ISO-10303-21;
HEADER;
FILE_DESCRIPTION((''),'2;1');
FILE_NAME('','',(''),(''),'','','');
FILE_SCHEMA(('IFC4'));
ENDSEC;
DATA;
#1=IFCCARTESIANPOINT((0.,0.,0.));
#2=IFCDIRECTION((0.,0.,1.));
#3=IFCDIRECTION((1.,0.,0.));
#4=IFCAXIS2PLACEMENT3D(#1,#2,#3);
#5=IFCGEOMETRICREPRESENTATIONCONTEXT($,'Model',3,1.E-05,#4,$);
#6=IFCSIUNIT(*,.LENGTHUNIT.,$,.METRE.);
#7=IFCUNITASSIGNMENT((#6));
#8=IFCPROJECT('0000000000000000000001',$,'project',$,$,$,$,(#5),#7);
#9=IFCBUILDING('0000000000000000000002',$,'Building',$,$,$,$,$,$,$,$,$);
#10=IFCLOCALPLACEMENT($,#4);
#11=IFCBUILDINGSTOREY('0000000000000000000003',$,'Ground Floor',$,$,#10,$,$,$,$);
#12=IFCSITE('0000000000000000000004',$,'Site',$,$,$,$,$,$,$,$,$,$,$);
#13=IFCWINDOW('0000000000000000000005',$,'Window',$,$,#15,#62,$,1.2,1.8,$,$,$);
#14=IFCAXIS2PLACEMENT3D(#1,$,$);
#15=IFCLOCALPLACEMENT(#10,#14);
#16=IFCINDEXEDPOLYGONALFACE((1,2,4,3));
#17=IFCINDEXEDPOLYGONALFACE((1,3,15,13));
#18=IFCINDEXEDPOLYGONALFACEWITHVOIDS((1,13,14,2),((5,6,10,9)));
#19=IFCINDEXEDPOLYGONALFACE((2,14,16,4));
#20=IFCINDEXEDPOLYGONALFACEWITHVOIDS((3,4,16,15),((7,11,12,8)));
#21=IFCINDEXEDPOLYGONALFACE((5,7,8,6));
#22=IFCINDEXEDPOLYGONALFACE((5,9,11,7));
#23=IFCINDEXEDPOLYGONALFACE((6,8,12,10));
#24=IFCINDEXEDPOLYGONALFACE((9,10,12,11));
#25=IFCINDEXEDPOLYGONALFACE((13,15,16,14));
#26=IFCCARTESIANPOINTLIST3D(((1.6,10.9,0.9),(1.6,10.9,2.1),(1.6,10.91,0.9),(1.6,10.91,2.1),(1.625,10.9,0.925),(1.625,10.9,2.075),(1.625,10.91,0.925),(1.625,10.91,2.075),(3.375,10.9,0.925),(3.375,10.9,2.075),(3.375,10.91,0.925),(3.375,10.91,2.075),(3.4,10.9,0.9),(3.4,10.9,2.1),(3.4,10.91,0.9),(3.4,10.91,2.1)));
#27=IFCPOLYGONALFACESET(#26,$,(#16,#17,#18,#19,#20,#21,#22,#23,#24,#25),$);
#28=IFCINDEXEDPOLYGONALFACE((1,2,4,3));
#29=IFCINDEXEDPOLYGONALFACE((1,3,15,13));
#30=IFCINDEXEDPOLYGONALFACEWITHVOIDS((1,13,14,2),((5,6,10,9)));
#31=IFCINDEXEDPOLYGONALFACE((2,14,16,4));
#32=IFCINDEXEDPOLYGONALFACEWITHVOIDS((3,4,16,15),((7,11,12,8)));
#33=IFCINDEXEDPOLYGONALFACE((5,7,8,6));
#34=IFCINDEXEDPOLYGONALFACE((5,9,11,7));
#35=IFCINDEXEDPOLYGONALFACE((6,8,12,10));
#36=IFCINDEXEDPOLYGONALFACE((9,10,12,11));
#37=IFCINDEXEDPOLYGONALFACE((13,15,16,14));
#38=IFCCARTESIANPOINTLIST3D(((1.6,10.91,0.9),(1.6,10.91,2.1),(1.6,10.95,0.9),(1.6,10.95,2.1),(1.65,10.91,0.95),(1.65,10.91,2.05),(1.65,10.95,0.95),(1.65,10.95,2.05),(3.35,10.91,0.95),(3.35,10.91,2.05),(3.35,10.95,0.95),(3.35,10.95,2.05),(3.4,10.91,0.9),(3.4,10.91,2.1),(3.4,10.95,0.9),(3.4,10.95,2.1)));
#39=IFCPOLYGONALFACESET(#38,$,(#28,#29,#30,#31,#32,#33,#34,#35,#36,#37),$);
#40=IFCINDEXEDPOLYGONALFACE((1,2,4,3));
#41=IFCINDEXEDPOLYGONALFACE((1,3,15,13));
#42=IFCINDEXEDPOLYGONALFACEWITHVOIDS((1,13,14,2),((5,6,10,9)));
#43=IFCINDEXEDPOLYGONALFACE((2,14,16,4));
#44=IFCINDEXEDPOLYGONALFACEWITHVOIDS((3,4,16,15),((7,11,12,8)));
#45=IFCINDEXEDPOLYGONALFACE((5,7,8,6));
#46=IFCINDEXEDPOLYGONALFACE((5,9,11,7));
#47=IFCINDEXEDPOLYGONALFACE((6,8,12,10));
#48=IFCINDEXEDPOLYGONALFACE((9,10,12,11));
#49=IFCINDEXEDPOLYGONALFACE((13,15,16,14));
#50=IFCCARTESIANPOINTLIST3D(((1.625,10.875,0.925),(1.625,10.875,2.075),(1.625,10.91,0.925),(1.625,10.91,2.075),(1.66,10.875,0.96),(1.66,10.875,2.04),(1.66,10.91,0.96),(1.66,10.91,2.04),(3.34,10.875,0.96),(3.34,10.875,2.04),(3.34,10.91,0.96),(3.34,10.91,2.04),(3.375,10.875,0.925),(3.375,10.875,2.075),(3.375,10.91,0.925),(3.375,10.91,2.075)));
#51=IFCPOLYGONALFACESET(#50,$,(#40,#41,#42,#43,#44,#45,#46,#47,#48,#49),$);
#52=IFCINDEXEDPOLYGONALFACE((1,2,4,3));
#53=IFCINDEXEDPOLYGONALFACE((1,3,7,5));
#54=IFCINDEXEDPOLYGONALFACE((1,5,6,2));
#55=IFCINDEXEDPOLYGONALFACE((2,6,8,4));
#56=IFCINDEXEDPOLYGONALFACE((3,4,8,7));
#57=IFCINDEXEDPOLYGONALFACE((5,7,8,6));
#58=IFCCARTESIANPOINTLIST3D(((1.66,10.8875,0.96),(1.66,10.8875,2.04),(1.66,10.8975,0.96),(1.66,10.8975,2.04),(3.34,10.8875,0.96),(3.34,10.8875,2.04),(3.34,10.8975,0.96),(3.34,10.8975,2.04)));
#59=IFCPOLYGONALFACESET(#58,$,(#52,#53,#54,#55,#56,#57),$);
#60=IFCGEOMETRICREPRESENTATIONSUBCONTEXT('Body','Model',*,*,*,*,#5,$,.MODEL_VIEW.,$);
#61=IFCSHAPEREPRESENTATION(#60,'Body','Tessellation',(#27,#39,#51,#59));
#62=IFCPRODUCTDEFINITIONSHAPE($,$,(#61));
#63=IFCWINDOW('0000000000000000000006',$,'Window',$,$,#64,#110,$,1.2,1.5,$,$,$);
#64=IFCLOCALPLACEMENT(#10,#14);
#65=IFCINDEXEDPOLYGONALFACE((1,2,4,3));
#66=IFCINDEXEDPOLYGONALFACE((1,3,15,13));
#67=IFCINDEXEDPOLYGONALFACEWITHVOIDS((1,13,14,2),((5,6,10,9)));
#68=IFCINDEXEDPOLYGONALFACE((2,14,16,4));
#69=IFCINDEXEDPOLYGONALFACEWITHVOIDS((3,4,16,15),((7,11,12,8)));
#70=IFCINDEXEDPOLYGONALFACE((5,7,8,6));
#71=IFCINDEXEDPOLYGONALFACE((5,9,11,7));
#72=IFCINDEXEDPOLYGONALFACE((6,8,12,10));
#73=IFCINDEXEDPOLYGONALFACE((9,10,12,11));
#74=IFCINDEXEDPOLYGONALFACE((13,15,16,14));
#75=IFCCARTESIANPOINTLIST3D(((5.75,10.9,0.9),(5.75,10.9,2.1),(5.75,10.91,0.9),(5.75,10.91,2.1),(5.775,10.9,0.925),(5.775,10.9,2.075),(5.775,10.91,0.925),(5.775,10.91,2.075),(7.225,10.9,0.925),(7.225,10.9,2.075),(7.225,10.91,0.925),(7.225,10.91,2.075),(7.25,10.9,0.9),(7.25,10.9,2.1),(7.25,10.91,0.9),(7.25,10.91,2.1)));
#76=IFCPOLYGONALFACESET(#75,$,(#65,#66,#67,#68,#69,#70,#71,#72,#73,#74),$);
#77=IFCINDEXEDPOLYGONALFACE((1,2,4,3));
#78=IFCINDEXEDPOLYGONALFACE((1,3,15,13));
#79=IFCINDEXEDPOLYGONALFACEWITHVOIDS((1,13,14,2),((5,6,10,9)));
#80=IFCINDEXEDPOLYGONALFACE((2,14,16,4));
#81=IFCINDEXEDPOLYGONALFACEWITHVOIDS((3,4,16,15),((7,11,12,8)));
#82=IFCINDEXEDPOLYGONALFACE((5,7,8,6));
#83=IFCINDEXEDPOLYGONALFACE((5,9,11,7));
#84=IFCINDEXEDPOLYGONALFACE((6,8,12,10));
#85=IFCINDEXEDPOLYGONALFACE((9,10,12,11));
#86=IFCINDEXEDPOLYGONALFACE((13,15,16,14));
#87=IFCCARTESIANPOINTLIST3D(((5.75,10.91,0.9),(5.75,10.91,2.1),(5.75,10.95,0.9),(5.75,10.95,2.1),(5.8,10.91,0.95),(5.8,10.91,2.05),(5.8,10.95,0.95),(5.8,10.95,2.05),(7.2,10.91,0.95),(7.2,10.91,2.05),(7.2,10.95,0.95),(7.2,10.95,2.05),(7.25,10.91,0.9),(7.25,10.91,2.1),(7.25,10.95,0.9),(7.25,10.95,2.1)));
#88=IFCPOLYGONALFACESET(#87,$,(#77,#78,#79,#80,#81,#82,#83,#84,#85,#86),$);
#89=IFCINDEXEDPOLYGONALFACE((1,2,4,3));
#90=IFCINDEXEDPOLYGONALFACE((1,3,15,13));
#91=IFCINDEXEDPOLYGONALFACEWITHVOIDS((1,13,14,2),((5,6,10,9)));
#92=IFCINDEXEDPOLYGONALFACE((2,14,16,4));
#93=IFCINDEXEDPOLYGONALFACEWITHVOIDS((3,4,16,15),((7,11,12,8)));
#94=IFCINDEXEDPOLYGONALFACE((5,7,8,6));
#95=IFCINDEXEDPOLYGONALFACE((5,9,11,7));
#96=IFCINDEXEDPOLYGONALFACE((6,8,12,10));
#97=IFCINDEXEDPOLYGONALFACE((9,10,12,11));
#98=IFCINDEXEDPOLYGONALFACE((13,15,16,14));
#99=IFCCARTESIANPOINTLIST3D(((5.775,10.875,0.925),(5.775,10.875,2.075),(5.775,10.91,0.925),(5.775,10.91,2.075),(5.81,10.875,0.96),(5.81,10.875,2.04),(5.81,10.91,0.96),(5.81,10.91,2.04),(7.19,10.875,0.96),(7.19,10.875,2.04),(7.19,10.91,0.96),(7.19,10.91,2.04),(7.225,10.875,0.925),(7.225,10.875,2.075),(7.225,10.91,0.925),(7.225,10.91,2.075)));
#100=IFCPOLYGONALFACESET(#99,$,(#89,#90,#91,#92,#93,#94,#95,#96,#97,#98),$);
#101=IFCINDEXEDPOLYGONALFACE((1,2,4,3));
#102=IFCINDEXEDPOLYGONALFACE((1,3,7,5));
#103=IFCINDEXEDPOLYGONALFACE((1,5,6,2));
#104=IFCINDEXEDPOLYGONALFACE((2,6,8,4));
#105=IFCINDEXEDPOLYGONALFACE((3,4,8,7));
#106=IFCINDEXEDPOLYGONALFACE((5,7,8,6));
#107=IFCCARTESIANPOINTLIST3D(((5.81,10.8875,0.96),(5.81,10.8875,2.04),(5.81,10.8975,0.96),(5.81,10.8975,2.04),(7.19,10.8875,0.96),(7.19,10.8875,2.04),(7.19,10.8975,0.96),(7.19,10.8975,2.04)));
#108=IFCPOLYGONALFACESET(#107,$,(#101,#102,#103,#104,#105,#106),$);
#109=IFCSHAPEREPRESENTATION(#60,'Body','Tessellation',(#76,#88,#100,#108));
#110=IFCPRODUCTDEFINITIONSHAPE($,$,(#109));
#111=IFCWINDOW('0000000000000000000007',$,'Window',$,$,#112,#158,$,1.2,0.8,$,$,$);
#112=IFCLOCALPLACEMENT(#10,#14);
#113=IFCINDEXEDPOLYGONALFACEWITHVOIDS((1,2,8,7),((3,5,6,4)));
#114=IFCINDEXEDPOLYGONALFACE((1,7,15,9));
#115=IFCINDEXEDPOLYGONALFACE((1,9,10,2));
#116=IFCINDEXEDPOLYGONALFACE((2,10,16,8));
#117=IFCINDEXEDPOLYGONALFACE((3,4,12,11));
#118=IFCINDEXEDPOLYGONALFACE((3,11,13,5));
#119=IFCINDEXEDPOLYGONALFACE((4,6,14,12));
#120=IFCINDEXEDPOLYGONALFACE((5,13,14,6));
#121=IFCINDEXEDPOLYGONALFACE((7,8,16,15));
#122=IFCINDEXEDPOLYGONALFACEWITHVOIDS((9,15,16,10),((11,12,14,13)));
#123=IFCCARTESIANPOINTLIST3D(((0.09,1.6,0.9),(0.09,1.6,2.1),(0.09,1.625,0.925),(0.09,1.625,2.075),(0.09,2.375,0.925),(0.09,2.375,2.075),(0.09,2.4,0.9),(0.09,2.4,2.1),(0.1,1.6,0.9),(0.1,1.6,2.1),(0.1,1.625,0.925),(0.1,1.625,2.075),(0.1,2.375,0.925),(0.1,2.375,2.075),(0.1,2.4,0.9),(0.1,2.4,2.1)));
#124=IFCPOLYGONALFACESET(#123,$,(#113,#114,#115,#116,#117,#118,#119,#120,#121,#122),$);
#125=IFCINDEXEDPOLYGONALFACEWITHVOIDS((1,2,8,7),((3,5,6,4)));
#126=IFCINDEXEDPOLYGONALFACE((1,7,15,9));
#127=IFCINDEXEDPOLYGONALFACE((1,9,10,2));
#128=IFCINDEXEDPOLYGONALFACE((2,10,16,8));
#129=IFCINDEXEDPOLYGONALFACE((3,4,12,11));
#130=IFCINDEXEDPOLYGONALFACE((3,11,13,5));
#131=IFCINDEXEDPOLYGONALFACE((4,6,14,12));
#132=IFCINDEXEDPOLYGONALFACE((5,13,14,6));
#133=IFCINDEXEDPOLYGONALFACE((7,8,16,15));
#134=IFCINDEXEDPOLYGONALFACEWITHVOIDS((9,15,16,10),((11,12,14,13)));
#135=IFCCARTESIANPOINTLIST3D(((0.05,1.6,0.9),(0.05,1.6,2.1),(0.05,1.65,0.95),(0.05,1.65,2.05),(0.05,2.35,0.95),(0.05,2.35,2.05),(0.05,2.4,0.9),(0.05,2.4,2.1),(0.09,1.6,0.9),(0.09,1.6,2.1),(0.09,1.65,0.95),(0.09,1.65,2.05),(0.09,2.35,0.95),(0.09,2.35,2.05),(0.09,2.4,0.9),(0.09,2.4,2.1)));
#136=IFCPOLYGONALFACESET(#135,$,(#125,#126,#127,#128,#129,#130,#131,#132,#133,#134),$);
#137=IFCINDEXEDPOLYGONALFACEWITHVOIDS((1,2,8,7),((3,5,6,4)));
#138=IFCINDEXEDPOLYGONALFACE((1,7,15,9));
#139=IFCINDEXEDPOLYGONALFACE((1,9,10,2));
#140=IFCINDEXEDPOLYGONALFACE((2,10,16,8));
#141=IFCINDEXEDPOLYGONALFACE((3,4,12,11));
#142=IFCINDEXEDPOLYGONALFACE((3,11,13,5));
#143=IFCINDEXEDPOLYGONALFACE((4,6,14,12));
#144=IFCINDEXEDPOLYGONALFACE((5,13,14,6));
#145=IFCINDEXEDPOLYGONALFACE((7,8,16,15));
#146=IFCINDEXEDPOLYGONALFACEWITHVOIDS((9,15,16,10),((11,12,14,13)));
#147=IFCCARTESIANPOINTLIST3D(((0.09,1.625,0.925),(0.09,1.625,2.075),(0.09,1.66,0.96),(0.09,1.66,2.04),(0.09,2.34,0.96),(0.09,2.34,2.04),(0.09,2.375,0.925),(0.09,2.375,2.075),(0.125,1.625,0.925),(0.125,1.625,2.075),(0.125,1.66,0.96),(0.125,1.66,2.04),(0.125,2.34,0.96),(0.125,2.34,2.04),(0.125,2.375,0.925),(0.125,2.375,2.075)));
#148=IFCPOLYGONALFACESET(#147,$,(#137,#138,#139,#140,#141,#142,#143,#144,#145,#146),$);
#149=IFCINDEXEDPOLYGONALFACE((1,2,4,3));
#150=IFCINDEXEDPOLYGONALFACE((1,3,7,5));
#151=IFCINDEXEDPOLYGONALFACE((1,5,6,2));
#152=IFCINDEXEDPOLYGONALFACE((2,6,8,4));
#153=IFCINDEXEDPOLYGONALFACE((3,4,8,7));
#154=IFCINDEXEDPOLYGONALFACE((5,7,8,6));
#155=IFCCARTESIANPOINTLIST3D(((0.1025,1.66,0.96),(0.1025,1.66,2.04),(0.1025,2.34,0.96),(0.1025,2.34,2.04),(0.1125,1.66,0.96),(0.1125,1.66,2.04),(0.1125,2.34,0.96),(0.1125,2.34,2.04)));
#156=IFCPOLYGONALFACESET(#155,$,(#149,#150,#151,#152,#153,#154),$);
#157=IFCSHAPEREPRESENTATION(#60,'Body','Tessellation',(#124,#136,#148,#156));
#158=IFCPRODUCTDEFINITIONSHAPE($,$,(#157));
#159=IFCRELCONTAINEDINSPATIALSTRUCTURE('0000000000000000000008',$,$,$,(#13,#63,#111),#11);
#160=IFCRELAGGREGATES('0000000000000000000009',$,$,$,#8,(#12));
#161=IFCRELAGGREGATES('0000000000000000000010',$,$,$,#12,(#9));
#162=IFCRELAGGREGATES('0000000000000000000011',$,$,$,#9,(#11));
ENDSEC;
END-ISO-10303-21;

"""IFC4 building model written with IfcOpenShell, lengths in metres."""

from ifc_helpers import new_model, si_unit, frame, origin_with_axes, place, context, subcontext, project, spatial, line, indexed_curve, outline, extrude, element, save


model = new_model("IFC4")

# Units and contexts
model_context = context("Model", 3, precision=1e-05, world=origin_with_axes())
body_context = subcontext(model_context, "Body", "Model", "MODEL_VIEW")
ifc_project = project(units=[si_unit("LENGTHUNIT", "METRE")], contexts=[model_context])

# Site, building, storey
site = spatial("IfcSite", under=ifc_project, Name="Site")
building = spatial("IfcBuilding", under=site, Name="Building")
storey_placement = place(None, origin_with_axes())
storey = spatial("IfcBuildingStorey", under=building, at=storey_placement, Name="Ground Floor")

# Windows
for number, where, z_axis, x_axis, name in (
    (1, (3.4, 11.0, 0.9), (0.0, 0.0, 1.0), (-1.0, 0.0, 0.0), "Window"),
):
    element("IfcWindow", number, at=place(storey_placement, frame(where, z_axis=z_axis, x_axis=x_axis)), inside=storey, Name=name, OverallHeight=1.2, OverallWidth=1.8, context=body_context, shape_type="SweptSolid", body=[
        extrude(outline(indexed_curve([(0.0, 0.0), (1.8, 0.0), (1.8, 1.2), (0.0, 1.2)], segments=[line(1, 2, 3, 4, 1)]), holes=[indexed_curve([(0.025, 0.025), (1.775, 0.025), (1.775, 1.175), (0.025, 1.175)], segments=[line(1, 2, 3, 4, 1)])]), frame((0.0, 0.09, 0.0), z_axis=(0.0, -1.0, 0.0), x_axis=(1.0, 0.0, 0.0)), (0.0, 0.0, -1.0), 0.01),
        extrude(outline(indexed_curve([(0.0, 0.0), (1.8, 0.0), (1.8, 1.2), (0.0, 1.2)], segments=[line(1, 2, 3, 4, 1)]), holes=[indexed_curve([(0.05, 0.05), (1.75, 0.05), (1.75, 1.15), (0.05, 1.15)], segments=[line(1, 2, 3, 4, 1)])]), frame((0.0, 0.05, 0.0), z_axis=(0.0, -1.0, 0.0), x_axis=(1.0, 0.0, 0.0)), (0.0, 0.0, -1.0), 0.04),
        extrude(outline(indexed_curve([(0.0, 0.0), (1.75, 0.0), (1.75, 1.15), (0.0, 1.15)], segments=[line(1, 2, 3, 4, 1)]), holes=[indexed_curve([(0.035, 0.035), (1.715, 0.035), (1.715, 1.115), (0.035, 1.115)], segments=[line(1, 2, 3, 4, 1)])]), frame((0.025, 0.09, 0.025), z_axis=(0.0, -1.0, 0.0), x_axis=(1.0, 0.0, 0.0)), (0.0, 0.0, -1.0), 0.035),
        extrude(outline(indexed_curve([(0.035, 0.035), (1.715, 0.035), (1.715, 1.115), (0.035, 1.115)], segments=[line(1, 2, 3, 4, 1)])), frame((0.025, 0.1025, 0.025), z_axis=(0.0, -1.0, 0.0), x_axis=(1.0, 0.0, 0.0)), (0.0, 0.0, -1.0), 0.01),
    ])
window_1_placement = place(storey_placement, frame((7.25, 11.0, 0.9), z_axis=(0.0, 0.0, 1.0), x_axis=(-1.0, 0.0, 0.0)))
element("IfcWindow", 2, at=window_1_placement, inside=storey, Name="Window", OverallHeight=1.2, OverallWidth=1.5, context=body_context, shape_type="SweptSolid", body=[
    extrude(outline(indexed_curve([(0.0, 0.0), (1.5, 0.0), (1.5, 1.2), (0.0, 1.2)], segments=[line(1, 2, 3, 4, 1)]), holes=[indexed_curve([(0.025, 0.025), (1.475, 0.025), (1.475, 1.175), (0.025, 1.175)], segments=[line(1, 2, 3, 4, 1)])]), frame((0.0, 0.09, 0.0), z_axis=(0.0, -1.0, 0.0), x_axis=(1.0, 0.0, 0.0)), (0.0, 0.0, -1.0), 0.01),
    extrude(outline(indexed_curve([(0.0, 0.0), (1.5, 0.0), (1.5, 1.2), (0.0, 1.2)], segments=[line(1, 2, 3, 4, 1)]), holes=[indexed_curve([(0.05, 0.05), (1.45, 0.05), (1.45, 1.15), (0.05, 1.15)], segments=[line(1, 2, 3, 4, 1)])]), frame((0.0, 0.05, 0.0), z_axis=(0.0, -1.0, 0.0), x_axis=(1.0, 0.0, 0.0)), (0.0, 0.0, -1.0), 0.04),
    extrude(outline(indexed_curve([(0.0, 0.0), (1.45, 0.0), (1.45, 1.15), (0.0, 1.15)], segments=[line(1, 2, 3, 4, 1)]), holes=[indexed_curve([(0.035, 0.035), (1.415, 0.035), (1.415, 1.115), (0.035, 1.115)], segments=[line(1, 2, 3, 4, 1)])]), frame((0.025, 0.09, 0.025), z_axis=(0.0, -1.0, 0.0), x_axis=(1.0, 0.0, 0.0)), (0.0, 0.0, -1.0), 0.035),
    extrude(outline(indexed_curve([(0.035, 0.035), (1.415, 0.035), (1.415, 1.115), (0.035, 1.115)], segments=[line(1, 2, 3, 4, 1)])), frame((0.025, 0.1025, 0.025), z_axis=(0.0, -1.0, 0.0), x_axis=(1.0, 0.0, 0.0)), (0.0, 0.0, -1.0), 0.01),
])
window_2_placement = place(storey_placement, frame((0.0, 2.4, 0.9), z_axis=(0.0, 0.0, 1.0), x_axis=(0.0, -1.0, 0.0)))
element("IfcWindow", 3, at=window_2_placement, inside=storey, Name="Window", OverallHeight=1.2, OverallWidth=0.8, context=body_context, shape_type="SweptSolid", body=[
    extrude(outline(indexed_curve([(0.0, 0.0), (0.8, 0.0), (0.8, 1.2), (0.0, 1.2)], segments=[line(1, 2, 3, 4, 1)]), holes=[indexed_curve([(0.025, 0.025), (0.775, 0.025), (0.775, 1.175), (0.025, 1.175)], segments=[line(1, 2, 3, 4, 1)])]), frame((0.0, 0.09, 0.0), z_axis=(0.0, -1.0, 0.0), x_axis=(1.0, 0.0, 0.0)), (0.0, 0.0, -1.0), 0.01),
    extrude(outline(indexed_curve([(0.0, 0.0), (0.8, 0.0), (0.8, 1.2), (0.0, 1.2)], segments=[line(1, 2, 3, 4, 1)]), holes=[indexed_curve([(0.05, 0.05), (0.75, 0.05), (0.75, 1.15), (0.05, 1.15)], segments=[line(1, 2, 3, 4, 1)])]), frame((0.0, 0.05, 0.0), z_axis=(0.0, -1.0, 0.0), x_axis=(1.0, 0.0, 0.0)), (0.0, 0.0, -1.0), 0.04),
    extrude(outline(indexed_curve([(0.0, 0.0), (0.75, 0.0), (0.75, 1.15), (0.0, 1.15)], segments=[line(1, 2, 3, 4, 1)]), holes=[indexed_curve([(0.035, 0.035), (0.715, 0.035), (0.715, 1.115), (0.035, 1.115)], segments=[line(1, 2, 3, 4, 1)])]), frame((0.025, 0.09, 0.025), z_axis=(0.0, -1.0, 0.0), x_axis=(1.0, 0.0, 0.0)), (0.0, 0.0, -1.0), 0.035),
    extrude(outline(indexed_curve([(0.035, 0.035), (0.715, 0.035), (0.715, 1.115), (0.035, 1.115)], segments=[line(1, 2, 3, 4, 1)])), frame((0.025, 0.1025, 0.025), z_axis=(0.0, -1.0, 0.0), x_axis=(1.0, 0.0, 0.0)), (0.0, 0.0, -1.0), 0.01),
])

save(model, "model.ifc")
